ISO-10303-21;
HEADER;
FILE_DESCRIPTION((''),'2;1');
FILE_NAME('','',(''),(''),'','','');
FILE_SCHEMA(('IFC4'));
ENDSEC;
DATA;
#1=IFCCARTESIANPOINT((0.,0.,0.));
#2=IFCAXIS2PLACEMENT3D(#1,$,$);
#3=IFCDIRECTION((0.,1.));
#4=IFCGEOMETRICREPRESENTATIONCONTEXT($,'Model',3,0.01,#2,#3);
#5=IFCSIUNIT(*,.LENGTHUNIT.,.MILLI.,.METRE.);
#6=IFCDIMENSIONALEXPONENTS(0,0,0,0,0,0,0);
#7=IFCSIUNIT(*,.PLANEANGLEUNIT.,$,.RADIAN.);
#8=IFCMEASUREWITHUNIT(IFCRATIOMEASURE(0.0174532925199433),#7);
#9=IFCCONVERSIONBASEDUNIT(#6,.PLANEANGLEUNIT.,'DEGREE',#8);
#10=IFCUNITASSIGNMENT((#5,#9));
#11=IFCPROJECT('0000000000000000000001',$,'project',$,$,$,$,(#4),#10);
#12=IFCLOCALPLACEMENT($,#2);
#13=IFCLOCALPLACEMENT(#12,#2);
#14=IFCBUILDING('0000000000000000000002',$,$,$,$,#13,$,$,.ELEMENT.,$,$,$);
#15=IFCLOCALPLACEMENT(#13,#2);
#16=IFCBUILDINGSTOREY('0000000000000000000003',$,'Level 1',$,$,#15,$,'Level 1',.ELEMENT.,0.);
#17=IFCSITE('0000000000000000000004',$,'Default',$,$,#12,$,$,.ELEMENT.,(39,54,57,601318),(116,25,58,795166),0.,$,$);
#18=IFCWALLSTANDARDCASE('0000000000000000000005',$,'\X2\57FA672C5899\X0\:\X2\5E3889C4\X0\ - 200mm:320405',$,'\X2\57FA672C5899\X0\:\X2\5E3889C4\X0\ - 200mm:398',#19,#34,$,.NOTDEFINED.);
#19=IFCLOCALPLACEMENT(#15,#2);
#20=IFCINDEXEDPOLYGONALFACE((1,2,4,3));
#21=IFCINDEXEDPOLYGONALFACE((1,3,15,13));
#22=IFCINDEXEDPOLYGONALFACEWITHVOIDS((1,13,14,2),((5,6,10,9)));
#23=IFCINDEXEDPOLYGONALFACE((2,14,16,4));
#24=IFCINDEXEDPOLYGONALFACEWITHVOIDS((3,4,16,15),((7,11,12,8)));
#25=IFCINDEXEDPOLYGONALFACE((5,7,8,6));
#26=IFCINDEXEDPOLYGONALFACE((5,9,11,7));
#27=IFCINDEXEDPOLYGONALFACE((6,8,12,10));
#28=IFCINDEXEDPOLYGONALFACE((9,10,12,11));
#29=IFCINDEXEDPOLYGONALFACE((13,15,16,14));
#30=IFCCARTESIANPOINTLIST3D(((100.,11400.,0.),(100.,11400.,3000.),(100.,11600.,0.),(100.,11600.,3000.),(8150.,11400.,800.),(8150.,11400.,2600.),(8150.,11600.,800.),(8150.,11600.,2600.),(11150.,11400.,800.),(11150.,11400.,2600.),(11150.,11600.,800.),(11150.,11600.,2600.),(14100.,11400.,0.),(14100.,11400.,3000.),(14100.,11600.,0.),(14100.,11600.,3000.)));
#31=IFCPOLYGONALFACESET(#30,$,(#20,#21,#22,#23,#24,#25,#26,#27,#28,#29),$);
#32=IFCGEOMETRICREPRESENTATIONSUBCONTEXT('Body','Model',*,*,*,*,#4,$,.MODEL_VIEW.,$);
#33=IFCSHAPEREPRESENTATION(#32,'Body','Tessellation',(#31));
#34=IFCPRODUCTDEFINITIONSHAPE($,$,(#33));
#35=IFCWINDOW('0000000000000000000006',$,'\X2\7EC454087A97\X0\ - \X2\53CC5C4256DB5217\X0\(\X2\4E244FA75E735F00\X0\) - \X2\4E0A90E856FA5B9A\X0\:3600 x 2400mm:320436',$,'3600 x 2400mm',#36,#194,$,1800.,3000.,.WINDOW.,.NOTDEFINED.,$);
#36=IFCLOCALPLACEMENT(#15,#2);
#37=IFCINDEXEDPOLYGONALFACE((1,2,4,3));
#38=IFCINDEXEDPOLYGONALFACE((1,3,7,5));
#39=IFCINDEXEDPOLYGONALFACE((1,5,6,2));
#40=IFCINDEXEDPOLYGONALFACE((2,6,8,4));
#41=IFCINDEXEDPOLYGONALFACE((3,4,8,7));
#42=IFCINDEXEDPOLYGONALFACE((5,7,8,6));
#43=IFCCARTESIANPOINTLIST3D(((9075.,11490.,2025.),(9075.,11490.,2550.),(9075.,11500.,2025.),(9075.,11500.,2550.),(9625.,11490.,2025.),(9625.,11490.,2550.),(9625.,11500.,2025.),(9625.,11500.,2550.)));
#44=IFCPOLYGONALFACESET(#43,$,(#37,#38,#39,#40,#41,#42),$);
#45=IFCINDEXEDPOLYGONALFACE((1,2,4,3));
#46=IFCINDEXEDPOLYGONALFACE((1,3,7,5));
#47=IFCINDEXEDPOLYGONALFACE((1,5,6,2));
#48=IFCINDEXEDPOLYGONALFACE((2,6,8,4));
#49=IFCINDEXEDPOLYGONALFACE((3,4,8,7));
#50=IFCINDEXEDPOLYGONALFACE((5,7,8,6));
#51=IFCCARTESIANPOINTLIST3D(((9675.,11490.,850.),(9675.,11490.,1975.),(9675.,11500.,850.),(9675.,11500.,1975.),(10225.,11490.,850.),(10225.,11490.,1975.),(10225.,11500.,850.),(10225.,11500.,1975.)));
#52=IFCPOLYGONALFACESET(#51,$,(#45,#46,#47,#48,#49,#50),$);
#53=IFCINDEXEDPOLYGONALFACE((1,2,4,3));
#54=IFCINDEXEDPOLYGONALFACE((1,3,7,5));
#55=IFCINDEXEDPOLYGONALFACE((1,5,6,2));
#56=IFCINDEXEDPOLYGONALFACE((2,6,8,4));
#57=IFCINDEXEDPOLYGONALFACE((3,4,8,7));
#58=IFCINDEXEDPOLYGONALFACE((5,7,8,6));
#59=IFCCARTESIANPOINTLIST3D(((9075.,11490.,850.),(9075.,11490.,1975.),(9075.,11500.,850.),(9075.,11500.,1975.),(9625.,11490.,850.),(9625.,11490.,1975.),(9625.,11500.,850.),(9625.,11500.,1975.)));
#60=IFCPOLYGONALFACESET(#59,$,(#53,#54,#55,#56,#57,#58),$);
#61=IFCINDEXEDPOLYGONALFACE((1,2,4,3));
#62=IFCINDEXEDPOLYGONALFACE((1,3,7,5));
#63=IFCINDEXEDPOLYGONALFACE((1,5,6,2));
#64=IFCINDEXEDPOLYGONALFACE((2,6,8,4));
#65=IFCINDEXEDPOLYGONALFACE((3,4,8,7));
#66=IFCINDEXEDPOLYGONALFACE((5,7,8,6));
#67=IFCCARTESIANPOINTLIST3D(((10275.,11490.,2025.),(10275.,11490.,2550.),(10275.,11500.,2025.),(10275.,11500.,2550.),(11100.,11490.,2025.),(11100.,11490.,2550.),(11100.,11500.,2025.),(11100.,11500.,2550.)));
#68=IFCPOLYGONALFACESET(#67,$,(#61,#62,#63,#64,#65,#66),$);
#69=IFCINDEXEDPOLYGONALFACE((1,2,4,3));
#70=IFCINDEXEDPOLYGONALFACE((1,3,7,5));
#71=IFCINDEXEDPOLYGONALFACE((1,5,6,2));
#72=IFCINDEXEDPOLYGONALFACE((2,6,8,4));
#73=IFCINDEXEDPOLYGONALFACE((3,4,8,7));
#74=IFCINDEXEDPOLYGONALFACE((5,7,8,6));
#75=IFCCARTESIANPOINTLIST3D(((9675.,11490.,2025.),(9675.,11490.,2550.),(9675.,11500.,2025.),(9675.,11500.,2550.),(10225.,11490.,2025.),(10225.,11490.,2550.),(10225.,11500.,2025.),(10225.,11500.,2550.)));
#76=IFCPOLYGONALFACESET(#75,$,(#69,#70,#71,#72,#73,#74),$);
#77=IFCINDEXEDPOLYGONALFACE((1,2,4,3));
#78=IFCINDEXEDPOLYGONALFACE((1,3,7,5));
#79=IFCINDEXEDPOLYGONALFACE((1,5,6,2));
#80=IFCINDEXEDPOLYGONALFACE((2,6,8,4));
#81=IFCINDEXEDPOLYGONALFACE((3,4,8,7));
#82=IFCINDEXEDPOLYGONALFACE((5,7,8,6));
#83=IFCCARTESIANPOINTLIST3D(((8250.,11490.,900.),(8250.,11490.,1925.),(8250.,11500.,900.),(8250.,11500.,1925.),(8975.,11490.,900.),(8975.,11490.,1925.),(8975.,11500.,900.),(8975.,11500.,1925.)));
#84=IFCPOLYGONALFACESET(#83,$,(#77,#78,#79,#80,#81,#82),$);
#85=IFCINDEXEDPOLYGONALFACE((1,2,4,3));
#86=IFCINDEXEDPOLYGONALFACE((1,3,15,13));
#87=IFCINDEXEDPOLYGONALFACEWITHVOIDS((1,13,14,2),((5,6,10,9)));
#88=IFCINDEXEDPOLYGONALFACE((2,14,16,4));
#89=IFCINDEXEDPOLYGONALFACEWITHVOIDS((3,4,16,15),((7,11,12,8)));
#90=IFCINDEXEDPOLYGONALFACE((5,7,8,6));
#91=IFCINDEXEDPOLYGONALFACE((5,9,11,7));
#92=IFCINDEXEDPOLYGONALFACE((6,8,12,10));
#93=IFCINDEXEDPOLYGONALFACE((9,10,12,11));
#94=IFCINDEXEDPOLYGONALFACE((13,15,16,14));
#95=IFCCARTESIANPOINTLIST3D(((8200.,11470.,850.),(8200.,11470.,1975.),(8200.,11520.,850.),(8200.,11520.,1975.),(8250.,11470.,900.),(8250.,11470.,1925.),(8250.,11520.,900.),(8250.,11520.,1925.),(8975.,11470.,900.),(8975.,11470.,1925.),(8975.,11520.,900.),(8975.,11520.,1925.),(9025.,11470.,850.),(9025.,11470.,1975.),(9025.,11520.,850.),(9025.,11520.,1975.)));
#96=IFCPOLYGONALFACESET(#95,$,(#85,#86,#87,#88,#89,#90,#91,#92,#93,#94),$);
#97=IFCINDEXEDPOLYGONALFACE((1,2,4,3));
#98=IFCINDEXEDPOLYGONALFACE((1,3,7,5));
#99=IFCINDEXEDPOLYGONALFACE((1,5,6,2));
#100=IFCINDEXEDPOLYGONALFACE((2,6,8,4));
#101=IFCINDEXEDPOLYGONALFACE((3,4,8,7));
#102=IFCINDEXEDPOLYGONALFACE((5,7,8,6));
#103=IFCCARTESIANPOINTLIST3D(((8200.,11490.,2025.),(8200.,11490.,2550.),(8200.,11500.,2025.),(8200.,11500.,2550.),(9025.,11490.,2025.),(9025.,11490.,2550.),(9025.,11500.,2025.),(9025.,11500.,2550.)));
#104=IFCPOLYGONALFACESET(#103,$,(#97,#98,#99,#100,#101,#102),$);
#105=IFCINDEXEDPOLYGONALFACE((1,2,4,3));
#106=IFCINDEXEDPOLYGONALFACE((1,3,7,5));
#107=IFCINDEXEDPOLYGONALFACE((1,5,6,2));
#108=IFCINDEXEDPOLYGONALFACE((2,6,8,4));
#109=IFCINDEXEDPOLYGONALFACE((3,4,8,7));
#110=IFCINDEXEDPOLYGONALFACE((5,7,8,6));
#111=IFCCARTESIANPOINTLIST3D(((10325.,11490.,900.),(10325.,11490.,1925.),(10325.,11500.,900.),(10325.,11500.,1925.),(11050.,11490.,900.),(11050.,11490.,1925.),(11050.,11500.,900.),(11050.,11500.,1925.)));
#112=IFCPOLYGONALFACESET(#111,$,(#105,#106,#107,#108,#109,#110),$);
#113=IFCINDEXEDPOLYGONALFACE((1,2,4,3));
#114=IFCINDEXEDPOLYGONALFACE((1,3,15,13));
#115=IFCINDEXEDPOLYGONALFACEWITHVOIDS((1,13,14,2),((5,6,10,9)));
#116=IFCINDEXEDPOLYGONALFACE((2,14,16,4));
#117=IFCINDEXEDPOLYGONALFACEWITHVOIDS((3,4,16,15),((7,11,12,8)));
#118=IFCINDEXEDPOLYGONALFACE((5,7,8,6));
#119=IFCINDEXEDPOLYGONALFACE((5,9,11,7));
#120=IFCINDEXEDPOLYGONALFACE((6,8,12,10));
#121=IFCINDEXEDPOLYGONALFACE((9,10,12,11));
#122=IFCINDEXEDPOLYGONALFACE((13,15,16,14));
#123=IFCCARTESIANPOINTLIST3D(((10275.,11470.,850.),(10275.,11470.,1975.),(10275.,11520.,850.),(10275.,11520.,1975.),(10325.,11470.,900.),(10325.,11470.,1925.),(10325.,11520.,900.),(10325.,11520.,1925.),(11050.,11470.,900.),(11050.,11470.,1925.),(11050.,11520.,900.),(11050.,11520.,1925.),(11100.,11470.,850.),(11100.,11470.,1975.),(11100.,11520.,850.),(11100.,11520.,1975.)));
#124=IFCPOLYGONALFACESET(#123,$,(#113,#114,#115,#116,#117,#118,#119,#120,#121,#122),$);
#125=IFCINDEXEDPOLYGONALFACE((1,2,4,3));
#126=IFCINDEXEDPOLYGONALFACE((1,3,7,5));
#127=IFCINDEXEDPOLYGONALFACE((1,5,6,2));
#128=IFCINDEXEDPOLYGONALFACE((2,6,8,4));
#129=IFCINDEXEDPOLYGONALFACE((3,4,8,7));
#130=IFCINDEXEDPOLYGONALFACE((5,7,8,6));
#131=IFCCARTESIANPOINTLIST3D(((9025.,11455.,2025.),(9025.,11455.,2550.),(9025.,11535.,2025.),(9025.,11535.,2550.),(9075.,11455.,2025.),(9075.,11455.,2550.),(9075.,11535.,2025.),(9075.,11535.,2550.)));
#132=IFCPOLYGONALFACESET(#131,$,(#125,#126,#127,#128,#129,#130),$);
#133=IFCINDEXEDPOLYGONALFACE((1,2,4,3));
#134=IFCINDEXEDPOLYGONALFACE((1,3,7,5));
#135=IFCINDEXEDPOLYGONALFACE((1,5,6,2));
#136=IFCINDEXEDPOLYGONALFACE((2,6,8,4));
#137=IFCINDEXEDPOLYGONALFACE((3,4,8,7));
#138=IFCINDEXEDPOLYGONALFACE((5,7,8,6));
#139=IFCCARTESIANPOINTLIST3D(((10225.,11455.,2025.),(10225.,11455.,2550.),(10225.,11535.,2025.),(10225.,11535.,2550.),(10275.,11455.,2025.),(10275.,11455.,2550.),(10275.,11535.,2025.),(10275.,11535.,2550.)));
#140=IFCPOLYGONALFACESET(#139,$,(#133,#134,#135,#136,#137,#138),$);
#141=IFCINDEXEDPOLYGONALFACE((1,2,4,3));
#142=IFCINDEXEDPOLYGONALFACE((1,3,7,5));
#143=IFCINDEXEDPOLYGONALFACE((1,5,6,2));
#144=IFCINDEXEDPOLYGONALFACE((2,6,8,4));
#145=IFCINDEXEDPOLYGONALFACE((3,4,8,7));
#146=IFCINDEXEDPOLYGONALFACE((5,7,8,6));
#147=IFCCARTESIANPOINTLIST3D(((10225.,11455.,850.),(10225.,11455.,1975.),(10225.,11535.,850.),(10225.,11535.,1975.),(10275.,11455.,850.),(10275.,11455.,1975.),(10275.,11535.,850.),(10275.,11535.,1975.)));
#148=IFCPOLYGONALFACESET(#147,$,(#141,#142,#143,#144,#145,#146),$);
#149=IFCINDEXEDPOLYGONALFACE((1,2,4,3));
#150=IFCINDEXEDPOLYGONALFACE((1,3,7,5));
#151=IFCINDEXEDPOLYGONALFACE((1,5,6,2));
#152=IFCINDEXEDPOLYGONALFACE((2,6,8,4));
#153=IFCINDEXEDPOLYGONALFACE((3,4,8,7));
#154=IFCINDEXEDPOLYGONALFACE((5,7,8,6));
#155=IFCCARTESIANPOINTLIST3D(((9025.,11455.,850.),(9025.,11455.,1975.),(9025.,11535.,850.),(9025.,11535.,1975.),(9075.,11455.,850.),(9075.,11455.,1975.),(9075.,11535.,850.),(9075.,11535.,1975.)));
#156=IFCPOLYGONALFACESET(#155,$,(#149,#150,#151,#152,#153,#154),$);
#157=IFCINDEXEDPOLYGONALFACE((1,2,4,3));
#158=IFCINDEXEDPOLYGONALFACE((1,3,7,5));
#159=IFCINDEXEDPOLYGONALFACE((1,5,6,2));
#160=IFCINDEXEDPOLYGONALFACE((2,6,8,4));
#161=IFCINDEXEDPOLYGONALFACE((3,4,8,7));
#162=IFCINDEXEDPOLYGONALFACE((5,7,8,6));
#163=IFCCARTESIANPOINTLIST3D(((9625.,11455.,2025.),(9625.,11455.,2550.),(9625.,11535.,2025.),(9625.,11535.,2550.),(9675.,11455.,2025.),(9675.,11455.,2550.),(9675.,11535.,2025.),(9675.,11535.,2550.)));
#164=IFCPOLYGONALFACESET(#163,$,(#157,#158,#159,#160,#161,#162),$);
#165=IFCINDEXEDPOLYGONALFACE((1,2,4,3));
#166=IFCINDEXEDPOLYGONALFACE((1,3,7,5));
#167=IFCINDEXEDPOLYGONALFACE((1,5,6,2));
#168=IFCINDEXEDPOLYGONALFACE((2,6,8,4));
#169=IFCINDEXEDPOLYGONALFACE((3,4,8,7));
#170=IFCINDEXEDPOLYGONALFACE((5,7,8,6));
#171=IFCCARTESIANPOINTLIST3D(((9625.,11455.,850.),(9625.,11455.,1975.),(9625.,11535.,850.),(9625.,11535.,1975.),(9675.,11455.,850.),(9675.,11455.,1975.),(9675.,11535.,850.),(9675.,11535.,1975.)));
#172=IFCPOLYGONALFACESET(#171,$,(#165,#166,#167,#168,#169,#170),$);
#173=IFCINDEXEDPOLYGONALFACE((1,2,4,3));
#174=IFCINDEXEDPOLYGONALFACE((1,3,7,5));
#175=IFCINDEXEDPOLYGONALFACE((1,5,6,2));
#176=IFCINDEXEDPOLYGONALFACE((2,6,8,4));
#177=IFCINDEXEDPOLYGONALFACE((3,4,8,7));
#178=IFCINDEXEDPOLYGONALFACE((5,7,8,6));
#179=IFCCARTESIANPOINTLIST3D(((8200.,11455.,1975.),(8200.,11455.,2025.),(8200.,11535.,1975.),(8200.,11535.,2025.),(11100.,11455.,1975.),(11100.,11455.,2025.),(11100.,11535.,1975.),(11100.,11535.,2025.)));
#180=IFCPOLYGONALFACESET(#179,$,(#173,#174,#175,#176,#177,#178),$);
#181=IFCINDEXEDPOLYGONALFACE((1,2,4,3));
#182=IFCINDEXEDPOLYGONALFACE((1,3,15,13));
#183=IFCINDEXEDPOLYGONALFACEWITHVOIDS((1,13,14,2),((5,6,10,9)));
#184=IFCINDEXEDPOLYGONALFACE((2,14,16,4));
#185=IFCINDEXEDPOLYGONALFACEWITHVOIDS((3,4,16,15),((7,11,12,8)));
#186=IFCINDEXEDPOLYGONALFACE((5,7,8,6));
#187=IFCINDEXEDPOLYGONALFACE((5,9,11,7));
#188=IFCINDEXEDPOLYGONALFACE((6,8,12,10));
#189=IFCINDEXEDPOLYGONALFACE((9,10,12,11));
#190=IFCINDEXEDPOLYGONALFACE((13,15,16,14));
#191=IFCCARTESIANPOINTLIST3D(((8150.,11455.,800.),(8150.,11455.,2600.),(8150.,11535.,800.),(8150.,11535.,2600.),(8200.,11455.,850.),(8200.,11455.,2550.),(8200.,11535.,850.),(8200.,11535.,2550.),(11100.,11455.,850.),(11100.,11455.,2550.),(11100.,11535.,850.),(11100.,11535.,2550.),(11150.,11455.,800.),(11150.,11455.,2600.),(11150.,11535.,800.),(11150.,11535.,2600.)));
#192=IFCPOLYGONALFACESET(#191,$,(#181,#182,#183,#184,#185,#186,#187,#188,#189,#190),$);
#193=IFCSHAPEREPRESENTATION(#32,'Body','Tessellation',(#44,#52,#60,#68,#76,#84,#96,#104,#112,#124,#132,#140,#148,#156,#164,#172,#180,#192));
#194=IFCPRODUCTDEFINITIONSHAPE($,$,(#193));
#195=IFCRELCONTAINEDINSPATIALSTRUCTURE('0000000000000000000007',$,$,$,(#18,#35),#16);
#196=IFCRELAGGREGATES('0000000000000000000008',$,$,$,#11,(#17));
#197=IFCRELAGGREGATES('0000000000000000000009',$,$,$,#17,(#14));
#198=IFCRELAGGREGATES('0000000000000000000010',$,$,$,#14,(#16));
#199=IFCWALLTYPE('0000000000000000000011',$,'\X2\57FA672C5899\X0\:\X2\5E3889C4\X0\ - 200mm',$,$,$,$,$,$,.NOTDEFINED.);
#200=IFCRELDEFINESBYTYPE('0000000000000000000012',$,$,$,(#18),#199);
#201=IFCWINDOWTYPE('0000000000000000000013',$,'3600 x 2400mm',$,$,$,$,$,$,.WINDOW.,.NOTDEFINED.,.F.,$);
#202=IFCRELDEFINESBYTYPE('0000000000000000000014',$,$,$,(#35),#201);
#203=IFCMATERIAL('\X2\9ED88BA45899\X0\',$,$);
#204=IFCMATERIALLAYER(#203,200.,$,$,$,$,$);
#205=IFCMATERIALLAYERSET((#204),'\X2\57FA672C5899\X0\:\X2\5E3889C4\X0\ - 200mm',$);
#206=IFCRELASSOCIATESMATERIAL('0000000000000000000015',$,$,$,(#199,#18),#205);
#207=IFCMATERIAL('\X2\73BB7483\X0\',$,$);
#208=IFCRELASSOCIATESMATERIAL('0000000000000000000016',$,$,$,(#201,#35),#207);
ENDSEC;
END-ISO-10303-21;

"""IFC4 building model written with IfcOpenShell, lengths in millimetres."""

from ifc_helpers import new_model, entity, si_unit, converted_unit, direction, frame, frame_2d, origin, origin_2d_with_axis, place, context, subcontext, project, spatial, polyline, rectangle, outline, extrude, source, transform, mapped, material, layer, layer_set, layer_usage, type_object, type_shapes, element, fill, save


model = new_model("IFC4")

# Units and contexts
model_context = context("Model", 3, precision=0.01, world=origin(), true_north=direction((0.0, 1.0)))
body_context = subcontext(model_context, "Body", "Model", "MODEL_VIEW")
ifc_project = project(units=[si_unit("LENGTHUNIT", "METRE", prefix="MILLI"), converted_unit("PLANEANGLEUNIT", "DEGREE", entity("IfcRatioMeasure", 0.0174532925199433), si_unit("PLANEANGLEUNIT", "RADIAN"), dimensions=[0, 0, 0, 0, 0, 0, 0])], contexts=[model_context])

# Site, building, storey
site_placement = place(None, origin())
site = spatial("IfcSite", under=ifc_project, at=site_placement, Name="Default", CompositionType="ELEMENT", RefLatitude=(39, 54, 57, 601318), RefLongitude=(116, 25, 58, 795166), RefElevation=0.0)
building_placement = place(site_placement, origin())
building = spatial("IfcBuilding", under=site, at=building_placement, CompositionType="ELEMENT")
storey_placement = place(building_placement, origin())
storey = spatial("IfcBuildingStorey", under=building, at=storey_placement, Name="Level 1", LongName="Level 1", CompositionType="ELEMENT", Elevation=0.0)

# Shared definitions
ifc_material_1 = material(Name="默认墙")
ifc_layer_1 = layer(ifc_material_1, 200.0)
ifc_layer_set_1 = layer_set([ifc_layer_1], Name="基本墙:常规 - 200mm")
wall_type = type_object("IfcWallType", Name="基本墙:常规 - 200mm", PredefinedType="NOTDEFINED", material=ifc_layer_set_1)
ifc_material_2 = material(Name="玻璃")

# Wall, opening, window
ifc_layer_usage_1 = layer_usage(ifc_layer_set_1, "AXIS2", "NEGATIVE", 100.0)
wall_1_placement = place(storey_placement, frame((100.0, 11500.0, 0.0)))
wall_1 = element("IfcWallStandardCase", 1, at=wall_1_placement, inside=storey, type_object=wall_type, material=ifc_layer_usage_1, Name="基本墙:常规 - 200mm:320405", ObjectType="基本墙:常规 - 200mm:398", PredefinedType="NOTDEFINED", context=body_context, shape_type="SweptSolid", body=[
    extrude(rectangle(XDim=14000.0, YDim=200.0, at=frame_2d((7000.0, 0.0), x_axis=(-1.0, 0.0))), origin(), (0.0, 0.0, 1.0), 3000.0),
])
opening_1_placement = place(wall_1_placement, frame((8050.0, -100.0, 800.0)))
opening_1 = element("IfcOpeningElement", 2, at=opening_1_placement, cuts=wall_1, ObjectType="Opening", PredefinedType="OPENING", context=body_context, shape_type="SweptSolid", body=[
    extrude(rectangle(XDim=1800.0, YDim=3000.0, at=frame_2d((900.0, 1500.0), x_axis=(1.0, 0.0))), frame((0.0, 0.0, 0.0), z_axis=(0.0, 1.0, 0.0), x_axis=(0.0, 0.0, 1.0)), (0.0, 0.0, 1.0), 200.0),
])
window_type_1 = type_object("IfcWindowType", Name="3600 x 2400mm", ParameterTakesPrecedence=False, PartitioningType="NOTDEFINED", PredefinedType="WINDOW", material=ifc_material_2)
shared_shape_1 = source(origin(), body_context, "Body", "SweptSolid", [
    extrude(rectangle(XDim=10.0, YDim=550.0, at=origin_2d_with_axis()), frame((1200.0, 95.0, 1225.0), z_axis=(0.0, 0.0, 1.0), x_axis=(0.0, 1.0, 0.0)), (0.0, 0.0, 1.0), 525.0),
    extrude(rectangle(XDim=10.0, YDim=550.0, at=origin_2d_with_axis()), frame((1800.0, 95.0, 50.0), z_axis=(0.0, 0.0, 1.0), x_axis=(0.0, 1.0, 0.0)), (0.0, 0.0, 1.0), 1125.0),
    extrude(rectangle(XDim=10.0, YDim=550.0, at=origin_2d_with_axis()), frame((1200.0, 95.0, 50.0), z_axis=(0.0, 0.0, 1.0), x_axis=(0.0, 1.0, 0.0)), (0.0, 0.0, 1.0), 1125.0),
    extrude(rectangle(XDim=10.0, YDim=825.0, at=origin_2d_with_axis()), frame((2537.5, 95.0, 1225.0), z_axis=(0.0, 0.0, 1.0), x_axis=(0.0, 1.0, 0.0)), (0.0, 0.0, 1.0), 525.0),
    extrude(rectangle(XDim=10.0, YDim=550.0, at=origin_2d_with_axis()), frame((1800.0, 95.0, 1225.0), z_axis=(0.0, 0.0, 1.0), x_axis=(0.0, 1.0, 0.0)), (0.0, 0.0, 1.0), 525.0),
    extrude(rectangle(XDim=10.0, YDim=725.0, at=origin_2d_with_axis()), frame((462.5, 95.0, 100.0), z_axis=(0.0, 0.0, 1.0), x_axis=(0.0, 1.0, 0.0)), (0.0, 0.0, 1.0), 1025.0),
    extrude(outline(polyline([(-562.5, -412.5), (562.5, -412.5), (562.5, 412.5), (-562.5, 412.5), (-562.5, -412.5)]), holes=[polyline([(512.5, -362.5), (-512.5, -362.5), (-512.5, 362.5), (512.5, 362.5), (512.5, -362.5)])]), frame((462.5, 70.0, 612.5), z_axis=(0.0, 1.0, 0.0), x_axis=(0.0, 0.0, -1.0)), (0.0, 0.0, 1.0), 50.0),
    extrude(rectangle(XDim=10.0, YDim=825.0, at=origin_2d_with_axis()), frame((462.5, 95.0, 1225.0), z_axis=(0.0, 0.0, 1.0), x_axis=(0.0, 1.0, 0.0)), (0.0, 0.0, 1.0), 525.0),
    extrude(rectangle(XDim=10.0, YDim=725.0, at=origin_2d_with_axis()), frame((2537.5, 95.0, 100.0), z_axis=(0.0, 0.0, 1.0), x_axis=(0.0, 1.0, 0.0)), (0.0, 0.0, 1.0), 1025.0),
    extrude(outline(polyline([(-562.5, -412.5), (562.5, -412.5), (562.5, 412.5), (-562.5, 412.5), (-562.5, -412.5)]), holes=[polyline([(512.5, -362.5), (-512.5, -362.5), (-512.5, 362.5), (512.5, 362.5), (512.5, -362.5)])]), frame((2537.5, 70.0, 612.5), z_axis=(0.0, 1.0, 0.0), x_axis=(0.0, 0.0, -1.0)), (0.0, 0.0, 1.0), 50.0),
    extrude(rectangle(XDim=80.0, YDim=50.0, at=origin_2d_with_axis()), frame((900.0, 95.0, 1225.0), z_axis=(0.0, 0.0, 1.0), x_axis=(0.0, -1.0, 0.0)), (0.0, 0.0, 1.0), 525.0),
    extrude(rectangle(XDim=80.0, YDim=50.0, at=origin_2d_with_axis()), frame((2100.0, 95.0, 1225.0), z_axis=(0.0, 0.0, 1.0), x_axis=(0.0, -1.0, 0.0)), (0.0, 0.0, 1.0), 525.0),
    extrude(rectangle(XDim=80.0, YDim=50.0, at=origin_2d_with_axis()), frame((2100.0, 95.0, 50.0), z_axis=(0.0, 0.0, 1.0), x_axis=(0.0, -1.0, 0.0)), (0.0, 0.0, 1.0), 1125.0),
    extrude(rectangle(XDim=80.0, YDim=50.0, at=origin_2d_with_axis()), frame((900.0, 95.0, 50.0), z_axis=(0.0, 0.0, 1.0), x_axis=(0.0, -1.0, 0.0)), (0.0, 0.0, 1.0), 1125.0),
    extrude(rectangle(XDim=80.0, YDim=50.0, at=origin_2d_with_axis()), frame((1500.0, 95.0, 1225.0), z_axis=(0.0, 0.0, 1.0), x_axis=(0.0, -1.0, 0.0)), (0.0, 0.0, 1.0), 525.0),
    extrude(rectangle(XDim=80.0, YDim=50.0, at=origin_2d_with_axis()), frame((1500.0, 95.0, 50.0), z_axis=(0.0, 0.0, 1.0), x_axis=(0.0, -1.0, 0.0)), (0.0, 0.0, 1.0), 1125.0),
    extrude(rectangle(XDim=80.0, YDim=2900.0, at=origin_2d_with_axis()), frame((1500.0, 95.0, 1175.0), z_axis=(0.0, 0.0, 1.0), x_axis=(0.0, -1.0, 0.0)), (0.0, 0.0, 1.0), 50.0),
    extrude(outline(polyline([(-1500.0, -900.0), (1500.0, -900.0), (1500.0, 900.0), (-1500.0, 900.0), (-1500.0, -900.0)]), holes=[polyline([(1450.0, -850.0), (-1450.0, -850.0), (-1450.0, 850.0), (1450.0, 850.0), (1450.0, -850.0)])]), frame((1500.0, 55.0, 900.0), z_axis=(0.0, 1.0, 0.0), x_axis=(1.0, 0.0, 0.0)), (0.0, 0.0, 1.0), 80.0),
])
type_shapes(window_type_1, [shared_shape_1])
window_1_placement = place(opening_1_placement, origin())
window_1 = element("IfcWindow", 3, at=window_1_placement, inside=storey, type_object=window_type_1, material=ifc_material_2, Name="组合窗 - 双层四列(两侧平开) - 上部固定:3600 x 2400mm:320436", ObjectType="3600 x 2400mm", OverallHeight=1800.0, OverallWidth=3000.0, PartitioningType="NOTDEFINED", PredefinedType="WINDOW", context=body_context, shape_type="MappedRepresentation", body=[
    mapped(shared_shape_1, transform((0.0, 0.0, 0.0), scale=1.0)),
])
fill(opening_1, window_1)

save(model, "model.ifc")
